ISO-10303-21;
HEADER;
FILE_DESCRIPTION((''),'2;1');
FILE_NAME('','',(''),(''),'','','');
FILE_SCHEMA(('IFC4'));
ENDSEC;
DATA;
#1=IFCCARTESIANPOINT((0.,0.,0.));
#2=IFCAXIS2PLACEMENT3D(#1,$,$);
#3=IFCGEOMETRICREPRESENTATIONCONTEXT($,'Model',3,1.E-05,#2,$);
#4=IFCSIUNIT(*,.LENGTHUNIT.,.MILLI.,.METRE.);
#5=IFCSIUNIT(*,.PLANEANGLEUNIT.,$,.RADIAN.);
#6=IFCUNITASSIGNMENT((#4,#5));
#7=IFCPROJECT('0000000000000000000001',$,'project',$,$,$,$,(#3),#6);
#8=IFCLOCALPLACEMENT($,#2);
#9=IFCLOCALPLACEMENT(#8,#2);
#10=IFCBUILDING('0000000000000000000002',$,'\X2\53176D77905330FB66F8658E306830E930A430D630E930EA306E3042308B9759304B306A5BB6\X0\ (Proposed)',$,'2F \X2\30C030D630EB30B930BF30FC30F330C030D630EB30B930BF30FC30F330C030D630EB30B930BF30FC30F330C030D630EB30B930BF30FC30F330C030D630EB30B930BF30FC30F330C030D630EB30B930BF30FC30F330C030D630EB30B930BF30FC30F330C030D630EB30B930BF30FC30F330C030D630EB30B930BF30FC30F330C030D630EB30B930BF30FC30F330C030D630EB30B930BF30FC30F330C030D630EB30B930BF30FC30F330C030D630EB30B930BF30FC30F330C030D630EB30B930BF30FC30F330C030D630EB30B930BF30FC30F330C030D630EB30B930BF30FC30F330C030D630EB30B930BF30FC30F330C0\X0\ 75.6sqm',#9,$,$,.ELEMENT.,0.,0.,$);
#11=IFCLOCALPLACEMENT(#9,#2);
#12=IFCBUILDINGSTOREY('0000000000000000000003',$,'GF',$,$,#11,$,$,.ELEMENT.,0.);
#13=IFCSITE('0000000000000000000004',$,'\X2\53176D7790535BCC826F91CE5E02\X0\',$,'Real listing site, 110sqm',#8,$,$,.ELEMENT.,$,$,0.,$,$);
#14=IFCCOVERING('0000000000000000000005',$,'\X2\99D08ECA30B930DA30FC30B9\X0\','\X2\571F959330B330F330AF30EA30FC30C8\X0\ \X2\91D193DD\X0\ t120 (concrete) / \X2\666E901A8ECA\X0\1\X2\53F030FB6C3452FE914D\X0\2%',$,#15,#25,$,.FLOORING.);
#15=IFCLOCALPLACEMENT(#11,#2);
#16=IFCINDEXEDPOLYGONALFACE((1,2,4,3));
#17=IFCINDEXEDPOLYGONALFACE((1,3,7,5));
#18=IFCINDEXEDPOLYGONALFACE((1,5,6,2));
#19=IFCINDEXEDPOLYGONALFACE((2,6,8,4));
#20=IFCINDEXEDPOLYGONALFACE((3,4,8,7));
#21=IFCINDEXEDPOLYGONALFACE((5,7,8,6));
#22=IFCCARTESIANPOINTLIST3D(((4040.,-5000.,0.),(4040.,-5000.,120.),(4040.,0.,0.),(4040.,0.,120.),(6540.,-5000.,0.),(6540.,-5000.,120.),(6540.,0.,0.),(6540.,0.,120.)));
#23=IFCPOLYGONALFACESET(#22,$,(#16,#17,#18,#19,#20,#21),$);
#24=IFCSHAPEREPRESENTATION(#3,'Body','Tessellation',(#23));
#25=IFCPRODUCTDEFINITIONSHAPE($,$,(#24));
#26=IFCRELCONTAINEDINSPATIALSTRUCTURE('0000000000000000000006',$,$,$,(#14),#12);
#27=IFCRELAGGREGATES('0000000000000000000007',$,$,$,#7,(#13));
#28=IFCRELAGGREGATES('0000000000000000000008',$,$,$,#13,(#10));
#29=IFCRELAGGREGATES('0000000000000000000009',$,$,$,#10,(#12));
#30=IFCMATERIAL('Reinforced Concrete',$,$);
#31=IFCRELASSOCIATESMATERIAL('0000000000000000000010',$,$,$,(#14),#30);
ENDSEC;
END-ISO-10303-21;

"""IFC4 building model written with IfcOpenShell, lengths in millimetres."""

from ifc_helpers import new_model, si_unit, frame, frame_2d, origin, place, context, project, spatial, rectangle, extrude, material, element, save


model = new_model("IFC4")

# Units and contexts
model_context = context("Model", 3, precision=1e-05, world=origin())
ifc_project = project(units=[si_unit("LENGTHUNIT", "METRE", prefix="MILLI"), si_unit("PLANEANGLEUNIT", "RADIAN")], contexts=[model_context])

# Site, building, storey
site_placement = place(None, origin())
site = spatial("IfcSite", under=ifc_project, at=site_placement, Name="北海道富良野市", ObjectType="Real listing site, 110sqm", CompositionType="ELEMENT", RefElevation=0.0)
building_placement = place(site_placement, origin())
building = spatial("IfcBuilding", under=site, at=building_placement, Name="北海道・書斎とライブラリのある静かな家 (Proposed)", ObjectType="2F ダブルスターンダブルスターンダブルスターンダブルスターンダブルスターンダブルスターンダブルスターンダブルスターンダブルスターンダブルスターンダブルスターンダブルスターンダブルスターンダブルスターンダブルスターンダブルスターンダブルスターンダ 75.6sqm", CompositionType="ELEMENT", ElevationOfRefHeight=0.0, ElevationOfTerrain=0.0)
storey_placement = place(building_placement, origin())
storey = spatial("IfcBuildingStorey", under=building, at=storey_placement, Name="GF", CompositionType="ELEMENT", Elevation=0.0)

# Covering
ifc_material_1 = material(Name="Reinforced Concrete")
covering_1_placement = place(storey_placement, frame((2020.0, -2500.0, 0.0)))
element("IfcCovering", 1, at=covering_1_placement, inside=storey, material=ifc_material_1, Name="駐車スペース", Description="土間コンクリート 金鏝 t120 (concrete) / 普通車1台・水勾配2%", PredefinedType="FLOORING", context=model_context, shape_type="SweptSolid", body=[
    extrude(rectangle(XDim=2500.0, YDim=5000.0, at=frame_2d((1250.0, 2500.0))), frame((2020.0, -2500.0, 0.0)), (0.0, 0.0, 1.0), 120.0),
])

save(model, "model.ifc")
